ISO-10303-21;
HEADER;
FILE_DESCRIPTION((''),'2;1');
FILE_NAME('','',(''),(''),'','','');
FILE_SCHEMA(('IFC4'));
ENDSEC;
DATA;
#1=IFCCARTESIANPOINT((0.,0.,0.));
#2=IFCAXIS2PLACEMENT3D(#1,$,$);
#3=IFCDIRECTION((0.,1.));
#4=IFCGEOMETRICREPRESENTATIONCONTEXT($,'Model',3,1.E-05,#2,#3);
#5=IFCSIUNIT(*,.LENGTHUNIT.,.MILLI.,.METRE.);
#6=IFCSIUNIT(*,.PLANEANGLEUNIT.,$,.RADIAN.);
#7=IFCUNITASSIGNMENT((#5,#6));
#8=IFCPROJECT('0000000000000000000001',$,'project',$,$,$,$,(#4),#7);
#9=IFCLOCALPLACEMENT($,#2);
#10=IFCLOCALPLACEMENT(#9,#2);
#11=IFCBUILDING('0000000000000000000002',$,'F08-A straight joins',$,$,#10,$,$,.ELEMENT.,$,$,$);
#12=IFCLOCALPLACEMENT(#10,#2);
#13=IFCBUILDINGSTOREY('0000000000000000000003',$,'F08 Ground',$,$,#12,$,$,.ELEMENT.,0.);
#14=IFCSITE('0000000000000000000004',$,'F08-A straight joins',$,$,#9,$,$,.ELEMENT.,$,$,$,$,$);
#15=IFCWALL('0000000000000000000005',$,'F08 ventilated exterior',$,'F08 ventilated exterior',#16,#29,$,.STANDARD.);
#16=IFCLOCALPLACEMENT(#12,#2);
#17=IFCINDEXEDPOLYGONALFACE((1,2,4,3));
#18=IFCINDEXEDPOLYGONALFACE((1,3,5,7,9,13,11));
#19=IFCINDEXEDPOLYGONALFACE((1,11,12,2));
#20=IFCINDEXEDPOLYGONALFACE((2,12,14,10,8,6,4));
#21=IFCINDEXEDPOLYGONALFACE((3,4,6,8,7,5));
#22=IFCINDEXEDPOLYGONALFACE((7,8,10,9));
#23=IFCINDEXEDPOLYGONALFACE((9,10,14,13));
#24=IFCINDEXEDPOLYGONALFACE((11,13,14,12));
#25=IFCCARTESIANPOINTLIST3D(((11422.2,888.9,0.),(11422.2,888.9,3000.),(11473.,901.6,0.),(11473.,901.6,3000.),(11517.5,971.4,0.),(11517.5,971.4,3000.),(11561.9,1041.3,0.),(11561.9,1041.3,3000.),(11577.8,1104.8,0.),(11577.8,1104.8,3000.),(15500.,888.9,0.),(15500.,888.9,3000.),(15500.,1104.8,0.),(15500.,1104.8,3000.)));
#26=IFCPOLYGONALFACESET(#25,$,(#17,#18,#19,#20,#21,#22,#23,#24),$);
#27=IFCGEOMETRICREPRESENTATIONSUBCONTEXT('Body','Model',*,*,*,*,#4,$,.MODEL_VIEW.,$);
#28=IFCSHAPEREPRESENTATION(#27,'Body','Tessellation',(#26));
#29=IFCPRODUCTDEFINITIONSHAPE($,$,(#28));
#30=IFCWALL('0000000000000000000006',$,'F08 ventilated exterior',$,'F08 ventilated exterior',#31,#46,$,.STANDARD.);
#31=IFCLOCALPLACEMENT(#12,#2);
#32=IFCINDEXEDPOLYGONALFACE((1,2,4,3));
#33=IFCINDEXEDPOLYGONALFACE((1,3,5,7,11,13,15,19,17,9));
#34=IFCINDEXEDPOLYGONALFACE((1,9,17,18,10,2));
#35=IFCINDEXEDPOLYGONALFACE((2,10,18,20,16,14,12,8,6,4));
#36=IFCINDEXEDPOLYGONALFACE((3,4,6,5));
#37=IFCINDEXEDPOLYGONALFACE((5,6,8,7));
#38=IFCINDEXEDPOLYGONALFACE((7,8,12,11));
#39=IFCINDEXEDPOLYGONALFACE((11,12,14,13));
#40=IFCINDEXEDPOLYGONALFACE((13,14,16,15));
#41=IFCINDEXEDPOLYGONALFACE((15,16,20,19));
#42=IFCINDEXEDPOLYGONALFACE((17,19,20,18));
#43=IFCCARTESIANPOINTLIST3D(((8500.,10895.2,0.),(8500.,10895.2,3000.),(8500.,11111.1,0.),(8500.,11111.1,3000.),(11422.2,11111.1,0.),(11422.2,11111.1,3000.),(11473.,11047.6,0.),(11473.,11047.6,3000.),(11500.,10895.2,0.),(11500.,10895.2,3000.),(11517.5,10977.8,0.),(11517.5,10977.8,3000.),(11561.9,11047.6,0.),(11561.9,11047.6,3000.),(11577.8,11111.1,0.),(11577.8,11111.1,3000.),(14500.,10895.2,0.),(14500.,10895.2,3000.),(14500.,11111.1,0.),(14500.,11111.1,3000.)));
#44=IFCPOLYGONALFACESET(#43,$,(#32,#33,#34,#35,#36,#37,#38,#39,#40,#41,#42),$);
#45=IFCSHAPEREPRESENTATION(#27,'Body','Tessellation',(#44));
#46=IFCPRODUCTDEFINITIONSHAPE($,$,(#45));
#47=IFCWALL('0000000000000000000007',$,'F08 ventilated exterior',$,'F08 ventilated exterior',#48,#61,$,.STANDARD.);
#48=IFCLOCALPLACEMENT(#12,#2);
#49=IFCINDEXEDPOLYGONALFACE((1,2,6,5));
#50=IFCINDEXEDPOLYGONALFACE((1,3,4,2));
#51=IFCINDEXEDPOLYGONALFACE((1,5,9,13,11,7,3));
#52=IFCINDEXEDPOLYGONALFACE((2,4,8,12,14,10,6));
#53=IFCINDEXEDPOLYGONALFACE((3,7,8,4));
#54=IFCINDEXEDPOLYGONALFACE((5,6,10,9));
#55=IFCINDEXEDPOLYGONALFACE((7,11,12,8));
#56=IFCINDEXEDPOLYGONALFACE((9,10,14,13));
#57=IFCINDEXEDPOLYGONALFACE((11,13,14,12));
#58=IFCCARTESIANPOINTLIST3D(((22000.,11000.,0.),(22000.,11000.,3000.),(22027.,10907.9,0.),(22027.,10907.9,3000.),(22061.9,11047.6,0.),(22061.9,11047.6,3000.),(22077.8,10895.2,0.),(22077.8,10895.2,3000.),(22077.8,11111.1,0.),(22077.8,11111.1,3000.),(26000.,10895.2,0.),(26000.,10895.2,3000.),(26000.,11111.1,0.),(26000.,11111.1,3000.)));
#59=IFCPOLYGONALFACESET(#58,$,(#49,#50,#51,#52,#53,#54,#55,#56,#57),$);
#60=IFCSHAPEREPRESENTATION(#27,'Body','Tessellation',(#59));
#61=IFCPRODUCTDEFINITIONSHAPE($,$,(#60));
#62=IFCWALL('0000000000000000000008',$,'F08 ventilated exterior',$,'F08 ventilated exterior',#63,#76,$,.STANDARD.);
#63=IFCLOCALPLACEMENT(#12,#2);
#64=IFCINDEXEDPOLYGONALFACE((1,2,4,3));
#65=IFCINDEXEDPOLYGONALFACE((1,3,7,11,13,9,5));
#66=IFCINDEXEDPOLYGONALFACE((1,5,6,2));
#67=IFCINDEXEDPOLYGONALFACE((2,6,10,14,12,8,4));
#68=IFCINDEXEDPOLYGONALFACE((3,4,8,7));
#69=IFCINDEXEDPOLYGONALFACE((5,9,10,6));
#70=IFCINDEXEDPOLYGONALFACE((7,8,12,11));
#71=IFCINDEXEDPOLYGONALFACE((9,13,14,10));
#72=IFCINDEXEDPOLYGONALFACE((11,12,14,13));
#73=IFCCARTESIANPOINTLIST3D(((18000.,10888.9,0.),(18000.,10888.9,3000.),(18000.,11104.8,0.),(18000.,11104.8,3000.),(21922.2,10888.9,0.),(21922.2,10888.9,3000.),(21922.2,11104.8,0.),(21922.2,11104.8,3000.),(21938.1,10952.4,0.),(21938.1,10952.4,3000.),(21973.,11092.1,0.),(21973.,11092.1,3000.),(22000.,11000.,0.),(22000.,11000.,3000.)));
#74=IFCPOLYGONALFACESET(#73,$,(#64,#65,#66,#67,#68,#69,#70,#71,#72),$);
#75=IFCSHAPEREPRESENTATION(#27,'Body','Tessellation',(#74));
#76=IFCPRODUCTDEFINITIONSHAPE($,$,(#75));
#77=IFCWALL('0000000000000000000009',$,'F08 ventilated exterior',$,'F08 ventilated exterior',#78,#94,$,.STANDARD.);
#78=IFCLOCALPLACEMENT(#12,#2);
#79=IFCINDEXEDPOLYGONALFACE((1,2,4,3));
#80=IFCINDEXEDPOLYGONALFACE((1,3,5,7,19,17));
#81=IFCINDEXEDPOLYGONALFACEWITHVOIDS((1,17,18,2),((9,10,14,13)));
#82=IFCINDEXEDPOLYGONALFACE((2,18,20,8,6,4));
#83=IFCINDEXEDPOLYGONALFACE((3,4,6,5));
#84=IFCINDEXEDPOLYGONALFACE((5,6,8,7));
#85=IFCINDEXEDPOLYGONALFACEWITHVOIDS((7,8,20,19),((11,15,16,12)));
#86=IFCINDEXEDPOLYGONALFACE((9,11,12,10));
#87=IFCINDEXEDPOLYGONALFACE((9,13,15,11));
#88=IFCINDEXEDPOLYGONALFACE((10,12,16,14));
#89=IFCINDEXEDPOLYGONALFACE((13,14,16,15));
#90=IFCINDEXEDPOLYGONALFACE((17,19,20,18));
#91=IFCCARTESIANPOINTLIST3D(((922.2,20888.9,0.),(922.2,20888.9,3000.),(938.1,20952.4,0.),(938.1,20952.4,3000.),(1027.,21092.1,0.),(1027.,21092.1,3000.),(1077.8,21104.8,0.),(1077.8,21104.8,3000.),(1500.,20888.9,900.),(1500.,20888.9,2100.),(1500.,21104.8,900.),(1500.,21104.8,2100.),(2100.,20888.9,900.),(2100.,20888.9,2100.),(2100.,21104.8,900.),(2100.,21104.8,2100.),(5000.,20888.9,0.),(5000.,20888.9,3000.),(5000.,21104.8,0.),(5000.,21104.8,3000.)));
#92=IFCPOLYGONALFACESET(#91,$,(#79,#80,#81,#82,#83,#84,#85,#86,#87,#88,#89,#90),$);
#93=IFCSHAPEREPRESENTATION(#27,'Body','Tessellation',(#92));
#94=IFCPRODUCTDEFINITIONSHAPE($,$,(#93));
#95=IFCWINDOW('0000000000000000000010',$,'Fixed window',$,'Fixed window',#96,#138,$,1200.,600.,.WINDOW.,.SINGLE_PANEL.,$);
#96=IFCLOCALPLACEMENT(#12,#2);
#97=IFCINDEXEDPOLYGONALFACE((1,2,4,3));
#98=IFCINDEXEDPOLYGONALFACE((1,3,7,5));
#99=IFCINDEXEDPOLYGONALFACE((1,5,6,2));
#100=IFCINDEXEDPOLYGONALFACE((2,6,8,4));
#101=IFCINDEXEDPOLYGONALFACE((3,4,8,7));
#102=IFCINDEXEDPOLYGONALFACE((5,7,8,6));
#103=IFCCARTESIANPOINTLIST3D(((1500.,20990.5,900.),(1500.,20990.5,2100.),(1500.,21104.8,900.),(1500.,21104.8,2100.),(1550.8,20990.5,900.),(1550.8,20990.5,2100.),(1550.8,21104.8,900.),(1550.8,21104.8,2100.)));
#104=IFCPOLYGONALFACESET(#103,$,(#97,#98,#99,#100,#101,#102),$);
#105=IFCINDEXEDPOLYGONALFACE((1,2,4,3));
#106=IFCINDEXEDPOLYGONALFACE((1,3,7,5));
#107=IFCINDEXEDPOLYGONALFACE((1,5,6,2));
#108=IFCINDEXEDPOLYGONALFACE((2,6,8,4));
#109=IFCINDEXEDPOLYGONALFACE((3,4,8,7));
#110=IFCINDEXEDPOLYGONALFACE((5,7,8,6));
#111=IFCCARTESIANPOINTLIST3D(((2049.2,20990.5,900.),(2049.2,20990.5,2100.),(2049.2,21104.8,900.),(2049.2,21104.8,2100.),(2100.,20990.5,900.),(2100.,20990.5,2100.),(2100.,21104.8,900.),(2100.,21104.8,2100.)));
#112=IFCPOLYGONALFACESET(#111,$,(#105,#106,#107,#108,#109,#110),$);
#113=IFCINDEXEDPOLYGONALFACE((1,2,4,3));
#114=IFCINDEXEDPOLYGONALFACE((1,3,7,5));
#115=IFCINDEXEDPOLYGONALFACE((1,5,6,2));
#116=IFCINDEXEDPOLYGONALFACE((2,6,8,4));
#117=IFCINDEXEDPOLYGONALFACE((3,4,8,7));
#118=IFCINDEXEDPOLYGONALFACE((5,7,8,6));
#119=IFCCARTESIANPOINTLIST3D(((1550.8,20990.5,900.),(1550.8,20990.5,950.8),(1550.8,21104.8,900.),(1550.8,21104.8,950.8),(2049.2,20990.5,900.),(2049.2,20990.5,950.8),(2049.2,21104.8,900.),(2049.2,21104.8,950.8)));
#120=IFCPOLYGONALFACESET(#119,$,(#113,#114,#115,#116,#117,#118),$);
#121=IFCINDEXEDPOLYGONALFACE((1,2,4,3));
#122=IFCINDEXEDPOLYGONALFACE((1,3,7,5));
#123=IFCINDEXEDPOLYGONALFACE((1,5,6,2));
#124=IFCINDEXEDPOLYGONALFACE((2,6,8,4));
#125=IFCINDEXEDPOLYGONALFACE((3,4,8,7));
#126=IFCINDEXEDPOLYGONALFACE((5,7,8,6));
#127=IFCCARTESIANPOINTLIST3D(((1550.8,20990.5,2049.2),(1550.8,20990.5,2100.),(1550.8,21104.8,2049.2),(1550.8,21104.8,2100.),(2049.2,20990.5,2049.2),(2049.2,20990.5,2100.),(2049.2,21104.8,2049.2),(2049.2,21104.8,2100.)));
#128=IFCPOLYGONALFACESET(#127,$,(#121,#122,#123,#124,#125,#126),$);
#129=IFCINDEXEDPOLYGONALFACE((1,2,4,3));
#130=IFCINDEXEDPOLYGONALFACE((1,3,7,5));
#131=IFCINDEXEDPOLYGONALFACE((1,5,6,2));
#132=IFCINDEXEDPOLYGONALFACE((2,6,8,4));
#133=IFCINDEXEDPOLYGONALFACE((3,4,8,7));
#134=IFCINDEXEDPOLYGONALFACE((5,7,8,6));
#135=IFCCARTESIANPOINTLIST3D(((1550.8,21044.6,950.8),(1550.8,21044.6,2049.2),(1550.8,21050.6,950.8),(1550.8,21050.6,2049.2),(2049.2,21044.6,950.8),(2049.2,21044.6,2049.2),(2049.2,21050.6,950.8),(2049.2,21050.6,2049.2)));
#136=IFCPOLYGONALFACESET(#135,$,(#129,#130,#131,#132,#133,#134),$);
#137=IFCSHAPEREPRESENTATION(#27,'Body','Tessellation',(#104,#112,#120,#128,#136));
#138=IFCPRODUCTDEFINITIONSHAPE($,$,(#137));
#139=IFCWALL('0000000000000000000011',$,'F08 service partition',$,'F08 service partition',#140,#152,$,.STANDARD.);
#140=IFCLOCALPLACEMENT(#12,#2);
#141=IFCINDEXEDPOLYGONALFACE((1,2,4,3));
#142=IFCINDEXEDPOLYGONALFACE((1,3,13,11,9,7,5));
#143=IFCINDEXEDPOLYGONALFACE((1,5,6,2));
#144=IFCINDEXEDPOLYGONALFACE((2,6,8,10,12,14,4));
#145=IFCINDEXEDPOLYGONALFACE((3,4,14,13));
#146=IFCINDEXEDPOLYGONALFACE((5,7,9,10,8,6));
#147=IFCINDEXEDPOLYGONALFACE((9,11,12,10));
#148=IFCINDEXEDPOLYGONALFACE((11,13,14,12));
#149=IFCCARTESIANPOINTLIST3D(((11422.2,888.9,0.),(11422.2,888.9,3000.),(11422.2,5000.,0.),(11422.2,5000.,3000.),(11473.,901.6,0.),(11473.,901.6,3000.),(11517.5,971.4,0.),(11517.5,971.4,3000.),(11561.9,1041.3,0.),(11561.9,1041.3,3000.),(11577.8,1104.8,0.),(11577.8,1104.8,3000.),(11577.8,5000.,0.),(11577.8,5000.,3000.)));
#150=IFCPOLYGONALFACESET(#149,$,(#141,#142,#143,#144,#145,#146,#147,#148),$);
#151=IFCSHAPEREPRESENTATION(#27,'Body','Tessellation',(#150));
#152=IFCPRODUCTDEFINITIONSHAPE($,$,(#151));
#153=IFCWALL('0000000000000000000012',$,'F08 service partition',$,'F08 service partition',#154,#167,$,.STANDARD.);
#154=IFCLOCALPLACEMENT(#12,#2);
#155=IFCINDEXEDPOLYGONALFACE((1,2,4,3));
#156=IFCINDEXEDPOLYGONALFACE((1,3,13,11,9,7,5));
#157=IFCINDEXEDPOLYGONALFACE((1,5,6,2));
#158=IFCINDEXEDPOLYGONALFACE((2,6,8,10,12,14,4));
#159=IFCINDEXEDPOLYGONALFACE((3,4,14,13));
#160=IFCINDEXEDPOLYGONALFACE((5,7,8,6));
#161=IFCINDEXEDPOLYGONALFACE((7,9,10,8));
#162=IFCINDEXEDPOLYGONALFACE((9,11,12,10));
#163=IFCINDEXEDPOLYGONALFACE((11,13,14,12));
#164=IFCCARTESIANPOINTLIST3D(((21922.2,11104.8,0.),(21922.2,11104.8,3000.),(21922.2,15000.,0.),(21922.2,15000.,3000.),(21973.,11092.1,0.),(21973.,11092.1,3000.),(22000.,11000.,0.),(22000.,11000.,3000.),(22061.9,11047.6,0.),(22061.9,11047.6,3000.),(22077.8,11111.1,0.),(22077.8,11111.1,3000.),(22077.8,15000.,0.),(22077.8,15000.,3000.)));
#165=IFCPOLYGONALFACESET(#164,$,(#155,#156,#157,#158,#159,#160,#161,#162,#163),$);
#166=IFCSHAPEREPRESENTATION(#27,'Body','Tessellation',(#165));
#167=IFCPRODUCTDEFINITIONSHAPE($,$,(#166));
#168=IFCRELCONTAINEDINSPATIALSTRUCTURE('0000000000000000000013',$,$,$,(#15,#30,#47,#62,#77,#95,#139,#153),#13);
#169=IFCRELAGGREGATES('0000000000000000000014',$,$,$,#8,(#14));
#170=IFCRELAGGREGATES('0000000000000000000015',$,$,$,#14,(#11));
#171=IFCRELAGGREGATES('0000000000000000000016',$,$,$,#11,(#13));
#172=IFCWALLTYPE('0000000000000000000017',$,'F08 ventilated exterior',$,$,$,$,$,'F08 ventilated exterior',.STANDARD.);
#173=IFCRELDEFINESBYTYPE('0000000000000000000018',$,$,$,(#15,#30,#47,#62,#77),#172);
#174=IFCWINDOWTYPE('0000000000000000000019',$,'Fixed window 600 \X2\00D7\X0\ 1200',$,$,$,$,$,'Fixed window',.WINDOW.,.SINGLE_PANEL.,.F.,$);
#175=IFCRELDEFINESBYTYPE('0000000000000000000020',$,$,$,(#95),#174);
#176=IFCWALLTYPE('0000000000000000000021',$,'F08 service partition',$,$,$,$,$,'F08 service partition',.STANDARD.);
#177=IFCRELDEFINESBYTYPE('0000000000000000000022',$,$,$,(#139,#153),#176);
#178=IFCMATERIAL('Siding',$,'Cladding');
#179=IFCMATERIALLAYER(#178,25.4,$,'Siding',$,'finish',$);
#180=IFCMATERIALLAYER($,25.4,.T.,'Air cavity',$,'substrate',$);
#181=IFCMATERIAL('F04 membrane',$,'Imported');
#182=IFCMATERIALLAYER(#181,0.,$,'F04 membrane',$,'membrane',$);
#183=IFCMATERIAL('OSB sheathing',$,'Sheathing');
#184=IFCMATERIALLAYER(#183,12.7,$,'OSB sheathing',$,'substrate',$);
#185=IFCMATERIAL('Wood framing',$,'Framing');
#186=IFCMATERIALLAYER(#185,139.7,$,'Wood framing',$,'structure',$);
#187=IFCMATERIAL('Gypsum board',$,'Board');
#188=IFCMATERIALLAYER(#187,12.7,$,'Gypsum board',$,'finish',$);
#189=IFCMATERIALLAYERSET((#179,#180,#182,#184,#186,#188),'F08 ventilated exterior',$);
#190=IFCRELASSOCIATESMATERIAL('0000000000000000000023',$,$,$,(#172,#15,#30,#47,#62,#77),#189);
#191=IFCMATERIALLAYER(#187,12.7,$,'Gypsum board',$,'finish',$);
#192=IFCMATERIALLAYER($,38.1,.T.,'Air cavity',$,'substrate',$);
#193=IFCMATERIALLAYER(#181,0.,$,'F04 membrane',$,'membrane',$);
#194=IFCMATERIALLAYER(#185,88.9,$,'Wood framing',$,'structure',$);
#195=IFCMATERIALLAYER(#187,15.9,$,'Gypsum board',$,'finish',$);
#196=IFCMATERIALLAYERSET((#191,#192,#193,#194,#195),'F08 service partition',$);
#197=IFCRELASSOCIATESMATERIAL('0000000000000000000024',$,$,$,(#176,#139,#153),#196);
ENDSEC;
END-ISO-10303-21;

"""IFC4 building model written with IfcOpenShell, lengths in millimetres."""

from ifc_helpers import new_model, si_unit, direction, frame, origin, origin_with_axes, place, context, subcontext, project, spatial, polyline, outline, extrude, material, layer, layer_set, layer_usage, type_object, element, fill, save


model = new_model("IFC4")

# Units and contexts
model_context = context("Model", 3, precision=1e-05, world=origin(), true_north=direction((0.0, 1.0)))
body_context = subcontext(model_context, "Body", "Model", "MODEL_VIEW")
ifc_project = project(units=[si_unit("LENGTHUNIT", "METRE", prefix="MILLI"), si_unit("PLANEANGLEUNIT", "RADIAN")], contexts=[model_context])

# Site, building, storey
site_placement = place(None, origin())
site = spatial("IfcSite", under=ifc_project, at=site_placement, Name="F08-A straight joins", CompositionType="ELEMENT")
building_placement = place(site_placement, origin())
building = spatial("IfcBuilding", under=site, at=building_placement, Name="F08-A straight joins", CompositionType="ELEMENT")
storey_placement = place(building_placement, origin())
storey = spatial("IfcBuildingStorey", under=building, at=storey_placement, Name="F08 Ground", CompositionType="ELEMENT", Elevation=0.0)

# Walls
ifc_material_1 = material(Name="Siding", Category="Cladding")
ifc_layer_1 = layer(ifc_material_1, 25.4, Name="Siding", Category="finish")
ifc_layer_2 = layer(None, 25.4, ventilated=True, Name="Air cavity", Category="substrate")
ifc_material_2 = material(Name="F04 membrane", Category="Imported")
ifc_layer_3 = layer(ifc_material_2, 0.0, Name="F04 membrane", Category="membrane")
ifc_material_3 = material(Name="OSB sheathing", Category="Sheathing")
ifc_layer_4 = layer(ifc_material_3, 12.7, Name="OSB sheathing", Category="substrate")
ifc_material_4 = material(Name="Wood framing", Category="Framing")
ifc_layer_5 = layer(ifc_material_4, 139.7, Name="Wood framing", Category="structure")
ifc_material_5 = material(Name="Gypsum board", Category="Board")
ifc_layer_6 = layer(ifc_material_5, 12.7, Name="Gypsum board", Category="finish")
ifc_layer_set_1 = layer_set([ifc_layer_1, ifc_layer_2, ifc_layer_3, ifc_layer_4, ifc_layer_5, ifc_layer_6], Name="F08 ventilated exterior")
wall_type_1 = type_object("IfcWallType", Name="F08 ventilated exterior", ElementType="F08 ventilated exterior", PredefinedType="STANDARD", material=ifc_layer_set_1)
ifc_layer_usage_1 = layer_usage(ifc_layer_set_1, "AXIS2", "NEGATIVE", 108.0)
wall_1_placement = place(storey_placement, frame((11500.0, 996.8, 0.0), z_axis=(0.0, 0.0, 1.0), x_axis=(1.0, 0.0, 0.0)))
element("IfcWall", 1, at=wall_1_placement, inside=storey, type_object=wall_type_1, material=ifc_layer_usage_1, Name="F08 ventilated exterior", ObjectType="F08 ventilated exterior", PredefinedType="STANDARD", context=body_context, shape_type="SweptSolid", body=[
    extrude(outline(polyline([(-77.8, -108.0), (4000.0, -108.0), (4000.0, 108.0), (77.8, 108.0), (61.9, 44.5), (17.5, -25.4), (-27.0, -95.2), (-77.8, -108.0)])), origin(), (0.0, 0.0, 1.0), 3000.0),
])
ifc_layer_usage_2 = layer_usage(ifc_layer_set_1, "AXIS2", "NEGATIVE", 108.0)
wall_2_placement = place(storey_placement, frame((8500.0, 11003.2, 0.0), z_axis=(0.0, 0.0, 1.0), x_axis=(1.0, 0.0, 0.0)))
element("IfcWall", 2, at=wall_2_placement, inside=storey, type_object=wall_type_1, material=ifc_layer_usage_2, Name="F08 ventilated exterior", ObjectType="F08 ventilated exterior", PredefinedType="STANDARD", context=body_context, shape_type="SweptSolid", body=[
    extrude(outline(polyline([(0.0, -108.0), (3000.0, -108.0), (6000.0, -108.0), (6000.0, 108.0), (3077.8, 108.0), (3061.9, 44.5), (3017.5, -25.4), (2973.0, 44.5), (2922.2, 108.0), (0.0, 108.0), (0.0, -108.0)])), origin(), (0.0, 0.0, 1.0), 3000.0),
])
ifc_layer_usage_3 = layer_usage(ifc_layer_set_1, "AXIS2", "NEGATIVE", 108.0)
wall_3_placement = place(storey_placement, frame((22000.0, 11003.2, 0.0), z_axis=(0.0, 0.0, 1.0), x_axis=(1.0, 0.0, 0.0)))
element("IfcWall", 3, at=wall_3_placement, inside=storey, type_object=wall_type_1, material=ifc_layer_usage_3, Name="F08 ventilated exterior", ObjectType="F08 ventilated exterior", PredefinedType="STANDARD", context=body_context, shape_type="SweptSolid", body=[
    extrude(outline(polyline([(77.8, -108.0), (4000.0, -108.0), (4000.0, 108.0), (77.8, 108.0), (61.9, 44.5), (0.0, -3.2), (27.0, -95.2), (77.8, -108.0)])), origin(), (0.0, 0.0, 1.0), 3000.0),
])
ifc_layer_usage_4 = layer_usage(ifc_layer_set_1, "AXIS2", "NEGATIVE", 108.0)
wall_4_placement = place(storey_placement, frame((22000.0, 10996.8, 0.0), z_axis=(0.0, 0.0, 1.0), x_axis=(-1.0, 0.0, 0.0)))
element("IfcWall", 4, at=wall_4_placement, inside=storey, type_object=wall_type_1, material=ifc_layer_usage_4, Name="F08 ventilated exterior", ObjectType="F08 ventilated exterior", PredefinedType="STANDARD", context=body_context, shape_type="SweptSolid", body=[
    extrude(outline(polyline([(77.8, -108.0), (4000.0, -108.0), (4000.0, 108.0), (77.8, 108.0), (61.9, 44.5), (0.0, -3.2), (27.0, -95.2), (77.8, -108.0)])), origin(), (0.0, 0.0, 1.0), 3000.0),
])

# Wall, opening, window
ifc_layer_usage_5 = layer_usage(ifc_layer_set_1, "AXIS2", "POSITIVE", -108.0)
wall_5_placement = place(storey_placement, frame((1000.0, 20996.8, 0.0), z_axis=(0.0, 0.0, 1.0), x_axis=(1.0, 0.0, 0.0)))
wall_5 = element("IfcWall", 5, at=wall_5_placement, inside=storey, type_object=wall_type_1, material=ifc_layer_usage_5, Name="F08 ventilated exterior", ObjectType="F08 ventilated exterior", PredefinedType="STANDARD", context=body_context, shape_type="SweptSolid", body=[
    extrude(outline(polyline([(-77.8, -108.0), (4000.0, -108.0), (4000.0, 108.0), (77.8, 108.0), (27.0, 95.2), (-17.5, 25.4), (-61.9, -44.5), (-77.8, -108.0)])), origin(), (0.0, 0.0, 1.0), 3000.0),
])
opening_placement = place(wall_5_placement, frame((500.0, 0.0, 900.0), z_axis=(0.0, 0.0, 1.0), x_axis=(1.0, 0.0, 0.0)))
opening = element("IfcOpeningElement", 6, at=opening_placement, cuts=wall_5, PredefinedType="OPENING", context=body_context, shape_type="SweptSolid", body=[
    extrude(outline(polyline([(0.0, -118.0), (600.0, -118.0), (600.0, 118.0), (0.0, 118.0), (0.0, -118.0)])), origin(), (0.0, 0.0, 1.0), 1200.0),
])
window_type = type_object("IfcWindowType", Name="Fixed window 600 × 1200", ElementType="Fixed window", ParameterTakesPrecedence=False, PartitioningType="SINGLE_PANEL", PredefinedType="WINDOW")
window_placement = place(opening_placement, origin_with_axes())
window = element("IfcWindow", 7, at=window_placement, inside=storey, type_object=window_type, Name="Fixed window", ObjectType="Fixed window", OverallHeight=1200.0, OverallWidth=600.0, PartitioningType="SINGLE_PANEL", PredefinedType="WINDOW", context=body_context, shape_type="SweptSolid", body=[
    extrude(outline(polyline([(0.0, -6.3), (50.8, -6.3), (50.8, 108.0), (0.0, 108.0), (0.0, -6.3)])), origin(), (0.0, 0.0, 1.0), 1200.0),
    extrude(outline(polyline([(549.2, -6.3), (600.0, -6.3), (600.0, 108.0), (549.2, 108.0), (549.2, -6.3)])), origin(), (0.0, 0.0, 1.0), 1200.0),
    extrude(outline(polyline([(50.8, -6.3), (549.2, -6.3), (549.2, 108.0), (50.8, 108.0), (50.8, -6.3)])), origin(), (0.0, 0.0, 1.0), 50.8),
    extrude(outline(polyline([(50.8, -6.3), (549.2, -6.3), (549.2, 108.0), (50.8, 108.0), (50.8, -6.3)])), frame((0.0, 0.0, 1149.2)), (0.0, 0.0, 1.0), 50.8),
    extrude(outline(polyline([(50.8, 47.8), (549.2, 47.8), (549.2, 53.8), (50.8, 53.8), (50.8, 47.8)])), frame((0.0, 0.0, 50.8)), (0.0, 0.0, 1.0), 1098.4),
])
fill(opening, window)

# Walls
ifc_layer_7 = layer(ifc_material_5, 12.7, Name="Gypsum board", Category="finish")
ifc_layer_8 = layer(None, 38.1, ventilated=True, Name="Air cavity", Category="substrate")
ifc_layer_9 = layer(ifc_material_2, 0.0, Name="F04 membrane", Category="membrane")
ifc_layer_10 = layer(ifc_material_4, 88.9, Name="Wood framing", Category="structure")
ifc_layer_11 = layer(ifc_material_5, 15.9, Name="Gypsum board", Category="finish")
ifc_layer_set_2 = layer_set([ifc_layer_7, ifc_layer_8, ifc_layer_9, ifc_layer_10, ifc_layer_11], Name="F08 service partition")
ifc_layer_usage_6 = layer_usage(ifc_layer_set_2, "AXIS2", "NEGATIVE", 77.8)
wall_type_2 = type_object("IfcWallType", Name="F08 service partition", ElementType="F08 service partition", PredefinedType="STANDARD", material=ifc_layer_set_2)
wall_6_placement = place(storey_placement, frame((11500.0, 996.8, 0.0), z_axis=(0.0, 0.0, 1.0), x_axis=(0.0, 1.0, 0.0)))
element("IfcWall", 8, at=wall_6_placement, inside=storey, type_object=wall_type_2, material=ifc_layer_usage_6, Name="F08 service partition", ObjectType="F08 service partition", PredefinedType="STANDARD", context=body_context, shape_type="SweptSolid", body=[
    extrude(outline(polyline([(108.0, -77.8), (4003.2, -77.8), (4003.2, 77.8), (-108.0, 77.8), (-95.2, 27.0), (-25.4, -17.5), (44.5, -61.9), (108.0, -77.8)])), origin(), (0.0, 0.0, 1.0), 3000.0),
])
ifc_layer_usage_7 = layer_usage(ifc_layer_set_2, "AXIS2", "NEGATIVE", 77.8)
wall_7_placement = place(storey_placement, frame((22000.0, 11000.0, 0.0), z_axis=(0.0, 0.0, 1.0), x_axis=(0.0, 1.0, 0.0)))
element("IfcWall", 9, at=wall_7_placement, inside=storey, type_object=wall_type_2, material=ifc_layer_usage_7, Name="F08 service partition", ObjectType="F08 service partition", PredefinedType="STANDARD", context=body_context, shape_type="SweptSolid", body=[
    extrude(outline(polyline([(111.1, -77.8), (4000.0, -77.8), (4000.0, 77.8), (104.8, 77.8), (92.1, 27.0), (0.0, 0.0), (47.6, -61.9), (111.1, -77.8)])), origin(), (0.0, 0.0, 1.0), 3000.0),
])

save(model, "model.ifc")
